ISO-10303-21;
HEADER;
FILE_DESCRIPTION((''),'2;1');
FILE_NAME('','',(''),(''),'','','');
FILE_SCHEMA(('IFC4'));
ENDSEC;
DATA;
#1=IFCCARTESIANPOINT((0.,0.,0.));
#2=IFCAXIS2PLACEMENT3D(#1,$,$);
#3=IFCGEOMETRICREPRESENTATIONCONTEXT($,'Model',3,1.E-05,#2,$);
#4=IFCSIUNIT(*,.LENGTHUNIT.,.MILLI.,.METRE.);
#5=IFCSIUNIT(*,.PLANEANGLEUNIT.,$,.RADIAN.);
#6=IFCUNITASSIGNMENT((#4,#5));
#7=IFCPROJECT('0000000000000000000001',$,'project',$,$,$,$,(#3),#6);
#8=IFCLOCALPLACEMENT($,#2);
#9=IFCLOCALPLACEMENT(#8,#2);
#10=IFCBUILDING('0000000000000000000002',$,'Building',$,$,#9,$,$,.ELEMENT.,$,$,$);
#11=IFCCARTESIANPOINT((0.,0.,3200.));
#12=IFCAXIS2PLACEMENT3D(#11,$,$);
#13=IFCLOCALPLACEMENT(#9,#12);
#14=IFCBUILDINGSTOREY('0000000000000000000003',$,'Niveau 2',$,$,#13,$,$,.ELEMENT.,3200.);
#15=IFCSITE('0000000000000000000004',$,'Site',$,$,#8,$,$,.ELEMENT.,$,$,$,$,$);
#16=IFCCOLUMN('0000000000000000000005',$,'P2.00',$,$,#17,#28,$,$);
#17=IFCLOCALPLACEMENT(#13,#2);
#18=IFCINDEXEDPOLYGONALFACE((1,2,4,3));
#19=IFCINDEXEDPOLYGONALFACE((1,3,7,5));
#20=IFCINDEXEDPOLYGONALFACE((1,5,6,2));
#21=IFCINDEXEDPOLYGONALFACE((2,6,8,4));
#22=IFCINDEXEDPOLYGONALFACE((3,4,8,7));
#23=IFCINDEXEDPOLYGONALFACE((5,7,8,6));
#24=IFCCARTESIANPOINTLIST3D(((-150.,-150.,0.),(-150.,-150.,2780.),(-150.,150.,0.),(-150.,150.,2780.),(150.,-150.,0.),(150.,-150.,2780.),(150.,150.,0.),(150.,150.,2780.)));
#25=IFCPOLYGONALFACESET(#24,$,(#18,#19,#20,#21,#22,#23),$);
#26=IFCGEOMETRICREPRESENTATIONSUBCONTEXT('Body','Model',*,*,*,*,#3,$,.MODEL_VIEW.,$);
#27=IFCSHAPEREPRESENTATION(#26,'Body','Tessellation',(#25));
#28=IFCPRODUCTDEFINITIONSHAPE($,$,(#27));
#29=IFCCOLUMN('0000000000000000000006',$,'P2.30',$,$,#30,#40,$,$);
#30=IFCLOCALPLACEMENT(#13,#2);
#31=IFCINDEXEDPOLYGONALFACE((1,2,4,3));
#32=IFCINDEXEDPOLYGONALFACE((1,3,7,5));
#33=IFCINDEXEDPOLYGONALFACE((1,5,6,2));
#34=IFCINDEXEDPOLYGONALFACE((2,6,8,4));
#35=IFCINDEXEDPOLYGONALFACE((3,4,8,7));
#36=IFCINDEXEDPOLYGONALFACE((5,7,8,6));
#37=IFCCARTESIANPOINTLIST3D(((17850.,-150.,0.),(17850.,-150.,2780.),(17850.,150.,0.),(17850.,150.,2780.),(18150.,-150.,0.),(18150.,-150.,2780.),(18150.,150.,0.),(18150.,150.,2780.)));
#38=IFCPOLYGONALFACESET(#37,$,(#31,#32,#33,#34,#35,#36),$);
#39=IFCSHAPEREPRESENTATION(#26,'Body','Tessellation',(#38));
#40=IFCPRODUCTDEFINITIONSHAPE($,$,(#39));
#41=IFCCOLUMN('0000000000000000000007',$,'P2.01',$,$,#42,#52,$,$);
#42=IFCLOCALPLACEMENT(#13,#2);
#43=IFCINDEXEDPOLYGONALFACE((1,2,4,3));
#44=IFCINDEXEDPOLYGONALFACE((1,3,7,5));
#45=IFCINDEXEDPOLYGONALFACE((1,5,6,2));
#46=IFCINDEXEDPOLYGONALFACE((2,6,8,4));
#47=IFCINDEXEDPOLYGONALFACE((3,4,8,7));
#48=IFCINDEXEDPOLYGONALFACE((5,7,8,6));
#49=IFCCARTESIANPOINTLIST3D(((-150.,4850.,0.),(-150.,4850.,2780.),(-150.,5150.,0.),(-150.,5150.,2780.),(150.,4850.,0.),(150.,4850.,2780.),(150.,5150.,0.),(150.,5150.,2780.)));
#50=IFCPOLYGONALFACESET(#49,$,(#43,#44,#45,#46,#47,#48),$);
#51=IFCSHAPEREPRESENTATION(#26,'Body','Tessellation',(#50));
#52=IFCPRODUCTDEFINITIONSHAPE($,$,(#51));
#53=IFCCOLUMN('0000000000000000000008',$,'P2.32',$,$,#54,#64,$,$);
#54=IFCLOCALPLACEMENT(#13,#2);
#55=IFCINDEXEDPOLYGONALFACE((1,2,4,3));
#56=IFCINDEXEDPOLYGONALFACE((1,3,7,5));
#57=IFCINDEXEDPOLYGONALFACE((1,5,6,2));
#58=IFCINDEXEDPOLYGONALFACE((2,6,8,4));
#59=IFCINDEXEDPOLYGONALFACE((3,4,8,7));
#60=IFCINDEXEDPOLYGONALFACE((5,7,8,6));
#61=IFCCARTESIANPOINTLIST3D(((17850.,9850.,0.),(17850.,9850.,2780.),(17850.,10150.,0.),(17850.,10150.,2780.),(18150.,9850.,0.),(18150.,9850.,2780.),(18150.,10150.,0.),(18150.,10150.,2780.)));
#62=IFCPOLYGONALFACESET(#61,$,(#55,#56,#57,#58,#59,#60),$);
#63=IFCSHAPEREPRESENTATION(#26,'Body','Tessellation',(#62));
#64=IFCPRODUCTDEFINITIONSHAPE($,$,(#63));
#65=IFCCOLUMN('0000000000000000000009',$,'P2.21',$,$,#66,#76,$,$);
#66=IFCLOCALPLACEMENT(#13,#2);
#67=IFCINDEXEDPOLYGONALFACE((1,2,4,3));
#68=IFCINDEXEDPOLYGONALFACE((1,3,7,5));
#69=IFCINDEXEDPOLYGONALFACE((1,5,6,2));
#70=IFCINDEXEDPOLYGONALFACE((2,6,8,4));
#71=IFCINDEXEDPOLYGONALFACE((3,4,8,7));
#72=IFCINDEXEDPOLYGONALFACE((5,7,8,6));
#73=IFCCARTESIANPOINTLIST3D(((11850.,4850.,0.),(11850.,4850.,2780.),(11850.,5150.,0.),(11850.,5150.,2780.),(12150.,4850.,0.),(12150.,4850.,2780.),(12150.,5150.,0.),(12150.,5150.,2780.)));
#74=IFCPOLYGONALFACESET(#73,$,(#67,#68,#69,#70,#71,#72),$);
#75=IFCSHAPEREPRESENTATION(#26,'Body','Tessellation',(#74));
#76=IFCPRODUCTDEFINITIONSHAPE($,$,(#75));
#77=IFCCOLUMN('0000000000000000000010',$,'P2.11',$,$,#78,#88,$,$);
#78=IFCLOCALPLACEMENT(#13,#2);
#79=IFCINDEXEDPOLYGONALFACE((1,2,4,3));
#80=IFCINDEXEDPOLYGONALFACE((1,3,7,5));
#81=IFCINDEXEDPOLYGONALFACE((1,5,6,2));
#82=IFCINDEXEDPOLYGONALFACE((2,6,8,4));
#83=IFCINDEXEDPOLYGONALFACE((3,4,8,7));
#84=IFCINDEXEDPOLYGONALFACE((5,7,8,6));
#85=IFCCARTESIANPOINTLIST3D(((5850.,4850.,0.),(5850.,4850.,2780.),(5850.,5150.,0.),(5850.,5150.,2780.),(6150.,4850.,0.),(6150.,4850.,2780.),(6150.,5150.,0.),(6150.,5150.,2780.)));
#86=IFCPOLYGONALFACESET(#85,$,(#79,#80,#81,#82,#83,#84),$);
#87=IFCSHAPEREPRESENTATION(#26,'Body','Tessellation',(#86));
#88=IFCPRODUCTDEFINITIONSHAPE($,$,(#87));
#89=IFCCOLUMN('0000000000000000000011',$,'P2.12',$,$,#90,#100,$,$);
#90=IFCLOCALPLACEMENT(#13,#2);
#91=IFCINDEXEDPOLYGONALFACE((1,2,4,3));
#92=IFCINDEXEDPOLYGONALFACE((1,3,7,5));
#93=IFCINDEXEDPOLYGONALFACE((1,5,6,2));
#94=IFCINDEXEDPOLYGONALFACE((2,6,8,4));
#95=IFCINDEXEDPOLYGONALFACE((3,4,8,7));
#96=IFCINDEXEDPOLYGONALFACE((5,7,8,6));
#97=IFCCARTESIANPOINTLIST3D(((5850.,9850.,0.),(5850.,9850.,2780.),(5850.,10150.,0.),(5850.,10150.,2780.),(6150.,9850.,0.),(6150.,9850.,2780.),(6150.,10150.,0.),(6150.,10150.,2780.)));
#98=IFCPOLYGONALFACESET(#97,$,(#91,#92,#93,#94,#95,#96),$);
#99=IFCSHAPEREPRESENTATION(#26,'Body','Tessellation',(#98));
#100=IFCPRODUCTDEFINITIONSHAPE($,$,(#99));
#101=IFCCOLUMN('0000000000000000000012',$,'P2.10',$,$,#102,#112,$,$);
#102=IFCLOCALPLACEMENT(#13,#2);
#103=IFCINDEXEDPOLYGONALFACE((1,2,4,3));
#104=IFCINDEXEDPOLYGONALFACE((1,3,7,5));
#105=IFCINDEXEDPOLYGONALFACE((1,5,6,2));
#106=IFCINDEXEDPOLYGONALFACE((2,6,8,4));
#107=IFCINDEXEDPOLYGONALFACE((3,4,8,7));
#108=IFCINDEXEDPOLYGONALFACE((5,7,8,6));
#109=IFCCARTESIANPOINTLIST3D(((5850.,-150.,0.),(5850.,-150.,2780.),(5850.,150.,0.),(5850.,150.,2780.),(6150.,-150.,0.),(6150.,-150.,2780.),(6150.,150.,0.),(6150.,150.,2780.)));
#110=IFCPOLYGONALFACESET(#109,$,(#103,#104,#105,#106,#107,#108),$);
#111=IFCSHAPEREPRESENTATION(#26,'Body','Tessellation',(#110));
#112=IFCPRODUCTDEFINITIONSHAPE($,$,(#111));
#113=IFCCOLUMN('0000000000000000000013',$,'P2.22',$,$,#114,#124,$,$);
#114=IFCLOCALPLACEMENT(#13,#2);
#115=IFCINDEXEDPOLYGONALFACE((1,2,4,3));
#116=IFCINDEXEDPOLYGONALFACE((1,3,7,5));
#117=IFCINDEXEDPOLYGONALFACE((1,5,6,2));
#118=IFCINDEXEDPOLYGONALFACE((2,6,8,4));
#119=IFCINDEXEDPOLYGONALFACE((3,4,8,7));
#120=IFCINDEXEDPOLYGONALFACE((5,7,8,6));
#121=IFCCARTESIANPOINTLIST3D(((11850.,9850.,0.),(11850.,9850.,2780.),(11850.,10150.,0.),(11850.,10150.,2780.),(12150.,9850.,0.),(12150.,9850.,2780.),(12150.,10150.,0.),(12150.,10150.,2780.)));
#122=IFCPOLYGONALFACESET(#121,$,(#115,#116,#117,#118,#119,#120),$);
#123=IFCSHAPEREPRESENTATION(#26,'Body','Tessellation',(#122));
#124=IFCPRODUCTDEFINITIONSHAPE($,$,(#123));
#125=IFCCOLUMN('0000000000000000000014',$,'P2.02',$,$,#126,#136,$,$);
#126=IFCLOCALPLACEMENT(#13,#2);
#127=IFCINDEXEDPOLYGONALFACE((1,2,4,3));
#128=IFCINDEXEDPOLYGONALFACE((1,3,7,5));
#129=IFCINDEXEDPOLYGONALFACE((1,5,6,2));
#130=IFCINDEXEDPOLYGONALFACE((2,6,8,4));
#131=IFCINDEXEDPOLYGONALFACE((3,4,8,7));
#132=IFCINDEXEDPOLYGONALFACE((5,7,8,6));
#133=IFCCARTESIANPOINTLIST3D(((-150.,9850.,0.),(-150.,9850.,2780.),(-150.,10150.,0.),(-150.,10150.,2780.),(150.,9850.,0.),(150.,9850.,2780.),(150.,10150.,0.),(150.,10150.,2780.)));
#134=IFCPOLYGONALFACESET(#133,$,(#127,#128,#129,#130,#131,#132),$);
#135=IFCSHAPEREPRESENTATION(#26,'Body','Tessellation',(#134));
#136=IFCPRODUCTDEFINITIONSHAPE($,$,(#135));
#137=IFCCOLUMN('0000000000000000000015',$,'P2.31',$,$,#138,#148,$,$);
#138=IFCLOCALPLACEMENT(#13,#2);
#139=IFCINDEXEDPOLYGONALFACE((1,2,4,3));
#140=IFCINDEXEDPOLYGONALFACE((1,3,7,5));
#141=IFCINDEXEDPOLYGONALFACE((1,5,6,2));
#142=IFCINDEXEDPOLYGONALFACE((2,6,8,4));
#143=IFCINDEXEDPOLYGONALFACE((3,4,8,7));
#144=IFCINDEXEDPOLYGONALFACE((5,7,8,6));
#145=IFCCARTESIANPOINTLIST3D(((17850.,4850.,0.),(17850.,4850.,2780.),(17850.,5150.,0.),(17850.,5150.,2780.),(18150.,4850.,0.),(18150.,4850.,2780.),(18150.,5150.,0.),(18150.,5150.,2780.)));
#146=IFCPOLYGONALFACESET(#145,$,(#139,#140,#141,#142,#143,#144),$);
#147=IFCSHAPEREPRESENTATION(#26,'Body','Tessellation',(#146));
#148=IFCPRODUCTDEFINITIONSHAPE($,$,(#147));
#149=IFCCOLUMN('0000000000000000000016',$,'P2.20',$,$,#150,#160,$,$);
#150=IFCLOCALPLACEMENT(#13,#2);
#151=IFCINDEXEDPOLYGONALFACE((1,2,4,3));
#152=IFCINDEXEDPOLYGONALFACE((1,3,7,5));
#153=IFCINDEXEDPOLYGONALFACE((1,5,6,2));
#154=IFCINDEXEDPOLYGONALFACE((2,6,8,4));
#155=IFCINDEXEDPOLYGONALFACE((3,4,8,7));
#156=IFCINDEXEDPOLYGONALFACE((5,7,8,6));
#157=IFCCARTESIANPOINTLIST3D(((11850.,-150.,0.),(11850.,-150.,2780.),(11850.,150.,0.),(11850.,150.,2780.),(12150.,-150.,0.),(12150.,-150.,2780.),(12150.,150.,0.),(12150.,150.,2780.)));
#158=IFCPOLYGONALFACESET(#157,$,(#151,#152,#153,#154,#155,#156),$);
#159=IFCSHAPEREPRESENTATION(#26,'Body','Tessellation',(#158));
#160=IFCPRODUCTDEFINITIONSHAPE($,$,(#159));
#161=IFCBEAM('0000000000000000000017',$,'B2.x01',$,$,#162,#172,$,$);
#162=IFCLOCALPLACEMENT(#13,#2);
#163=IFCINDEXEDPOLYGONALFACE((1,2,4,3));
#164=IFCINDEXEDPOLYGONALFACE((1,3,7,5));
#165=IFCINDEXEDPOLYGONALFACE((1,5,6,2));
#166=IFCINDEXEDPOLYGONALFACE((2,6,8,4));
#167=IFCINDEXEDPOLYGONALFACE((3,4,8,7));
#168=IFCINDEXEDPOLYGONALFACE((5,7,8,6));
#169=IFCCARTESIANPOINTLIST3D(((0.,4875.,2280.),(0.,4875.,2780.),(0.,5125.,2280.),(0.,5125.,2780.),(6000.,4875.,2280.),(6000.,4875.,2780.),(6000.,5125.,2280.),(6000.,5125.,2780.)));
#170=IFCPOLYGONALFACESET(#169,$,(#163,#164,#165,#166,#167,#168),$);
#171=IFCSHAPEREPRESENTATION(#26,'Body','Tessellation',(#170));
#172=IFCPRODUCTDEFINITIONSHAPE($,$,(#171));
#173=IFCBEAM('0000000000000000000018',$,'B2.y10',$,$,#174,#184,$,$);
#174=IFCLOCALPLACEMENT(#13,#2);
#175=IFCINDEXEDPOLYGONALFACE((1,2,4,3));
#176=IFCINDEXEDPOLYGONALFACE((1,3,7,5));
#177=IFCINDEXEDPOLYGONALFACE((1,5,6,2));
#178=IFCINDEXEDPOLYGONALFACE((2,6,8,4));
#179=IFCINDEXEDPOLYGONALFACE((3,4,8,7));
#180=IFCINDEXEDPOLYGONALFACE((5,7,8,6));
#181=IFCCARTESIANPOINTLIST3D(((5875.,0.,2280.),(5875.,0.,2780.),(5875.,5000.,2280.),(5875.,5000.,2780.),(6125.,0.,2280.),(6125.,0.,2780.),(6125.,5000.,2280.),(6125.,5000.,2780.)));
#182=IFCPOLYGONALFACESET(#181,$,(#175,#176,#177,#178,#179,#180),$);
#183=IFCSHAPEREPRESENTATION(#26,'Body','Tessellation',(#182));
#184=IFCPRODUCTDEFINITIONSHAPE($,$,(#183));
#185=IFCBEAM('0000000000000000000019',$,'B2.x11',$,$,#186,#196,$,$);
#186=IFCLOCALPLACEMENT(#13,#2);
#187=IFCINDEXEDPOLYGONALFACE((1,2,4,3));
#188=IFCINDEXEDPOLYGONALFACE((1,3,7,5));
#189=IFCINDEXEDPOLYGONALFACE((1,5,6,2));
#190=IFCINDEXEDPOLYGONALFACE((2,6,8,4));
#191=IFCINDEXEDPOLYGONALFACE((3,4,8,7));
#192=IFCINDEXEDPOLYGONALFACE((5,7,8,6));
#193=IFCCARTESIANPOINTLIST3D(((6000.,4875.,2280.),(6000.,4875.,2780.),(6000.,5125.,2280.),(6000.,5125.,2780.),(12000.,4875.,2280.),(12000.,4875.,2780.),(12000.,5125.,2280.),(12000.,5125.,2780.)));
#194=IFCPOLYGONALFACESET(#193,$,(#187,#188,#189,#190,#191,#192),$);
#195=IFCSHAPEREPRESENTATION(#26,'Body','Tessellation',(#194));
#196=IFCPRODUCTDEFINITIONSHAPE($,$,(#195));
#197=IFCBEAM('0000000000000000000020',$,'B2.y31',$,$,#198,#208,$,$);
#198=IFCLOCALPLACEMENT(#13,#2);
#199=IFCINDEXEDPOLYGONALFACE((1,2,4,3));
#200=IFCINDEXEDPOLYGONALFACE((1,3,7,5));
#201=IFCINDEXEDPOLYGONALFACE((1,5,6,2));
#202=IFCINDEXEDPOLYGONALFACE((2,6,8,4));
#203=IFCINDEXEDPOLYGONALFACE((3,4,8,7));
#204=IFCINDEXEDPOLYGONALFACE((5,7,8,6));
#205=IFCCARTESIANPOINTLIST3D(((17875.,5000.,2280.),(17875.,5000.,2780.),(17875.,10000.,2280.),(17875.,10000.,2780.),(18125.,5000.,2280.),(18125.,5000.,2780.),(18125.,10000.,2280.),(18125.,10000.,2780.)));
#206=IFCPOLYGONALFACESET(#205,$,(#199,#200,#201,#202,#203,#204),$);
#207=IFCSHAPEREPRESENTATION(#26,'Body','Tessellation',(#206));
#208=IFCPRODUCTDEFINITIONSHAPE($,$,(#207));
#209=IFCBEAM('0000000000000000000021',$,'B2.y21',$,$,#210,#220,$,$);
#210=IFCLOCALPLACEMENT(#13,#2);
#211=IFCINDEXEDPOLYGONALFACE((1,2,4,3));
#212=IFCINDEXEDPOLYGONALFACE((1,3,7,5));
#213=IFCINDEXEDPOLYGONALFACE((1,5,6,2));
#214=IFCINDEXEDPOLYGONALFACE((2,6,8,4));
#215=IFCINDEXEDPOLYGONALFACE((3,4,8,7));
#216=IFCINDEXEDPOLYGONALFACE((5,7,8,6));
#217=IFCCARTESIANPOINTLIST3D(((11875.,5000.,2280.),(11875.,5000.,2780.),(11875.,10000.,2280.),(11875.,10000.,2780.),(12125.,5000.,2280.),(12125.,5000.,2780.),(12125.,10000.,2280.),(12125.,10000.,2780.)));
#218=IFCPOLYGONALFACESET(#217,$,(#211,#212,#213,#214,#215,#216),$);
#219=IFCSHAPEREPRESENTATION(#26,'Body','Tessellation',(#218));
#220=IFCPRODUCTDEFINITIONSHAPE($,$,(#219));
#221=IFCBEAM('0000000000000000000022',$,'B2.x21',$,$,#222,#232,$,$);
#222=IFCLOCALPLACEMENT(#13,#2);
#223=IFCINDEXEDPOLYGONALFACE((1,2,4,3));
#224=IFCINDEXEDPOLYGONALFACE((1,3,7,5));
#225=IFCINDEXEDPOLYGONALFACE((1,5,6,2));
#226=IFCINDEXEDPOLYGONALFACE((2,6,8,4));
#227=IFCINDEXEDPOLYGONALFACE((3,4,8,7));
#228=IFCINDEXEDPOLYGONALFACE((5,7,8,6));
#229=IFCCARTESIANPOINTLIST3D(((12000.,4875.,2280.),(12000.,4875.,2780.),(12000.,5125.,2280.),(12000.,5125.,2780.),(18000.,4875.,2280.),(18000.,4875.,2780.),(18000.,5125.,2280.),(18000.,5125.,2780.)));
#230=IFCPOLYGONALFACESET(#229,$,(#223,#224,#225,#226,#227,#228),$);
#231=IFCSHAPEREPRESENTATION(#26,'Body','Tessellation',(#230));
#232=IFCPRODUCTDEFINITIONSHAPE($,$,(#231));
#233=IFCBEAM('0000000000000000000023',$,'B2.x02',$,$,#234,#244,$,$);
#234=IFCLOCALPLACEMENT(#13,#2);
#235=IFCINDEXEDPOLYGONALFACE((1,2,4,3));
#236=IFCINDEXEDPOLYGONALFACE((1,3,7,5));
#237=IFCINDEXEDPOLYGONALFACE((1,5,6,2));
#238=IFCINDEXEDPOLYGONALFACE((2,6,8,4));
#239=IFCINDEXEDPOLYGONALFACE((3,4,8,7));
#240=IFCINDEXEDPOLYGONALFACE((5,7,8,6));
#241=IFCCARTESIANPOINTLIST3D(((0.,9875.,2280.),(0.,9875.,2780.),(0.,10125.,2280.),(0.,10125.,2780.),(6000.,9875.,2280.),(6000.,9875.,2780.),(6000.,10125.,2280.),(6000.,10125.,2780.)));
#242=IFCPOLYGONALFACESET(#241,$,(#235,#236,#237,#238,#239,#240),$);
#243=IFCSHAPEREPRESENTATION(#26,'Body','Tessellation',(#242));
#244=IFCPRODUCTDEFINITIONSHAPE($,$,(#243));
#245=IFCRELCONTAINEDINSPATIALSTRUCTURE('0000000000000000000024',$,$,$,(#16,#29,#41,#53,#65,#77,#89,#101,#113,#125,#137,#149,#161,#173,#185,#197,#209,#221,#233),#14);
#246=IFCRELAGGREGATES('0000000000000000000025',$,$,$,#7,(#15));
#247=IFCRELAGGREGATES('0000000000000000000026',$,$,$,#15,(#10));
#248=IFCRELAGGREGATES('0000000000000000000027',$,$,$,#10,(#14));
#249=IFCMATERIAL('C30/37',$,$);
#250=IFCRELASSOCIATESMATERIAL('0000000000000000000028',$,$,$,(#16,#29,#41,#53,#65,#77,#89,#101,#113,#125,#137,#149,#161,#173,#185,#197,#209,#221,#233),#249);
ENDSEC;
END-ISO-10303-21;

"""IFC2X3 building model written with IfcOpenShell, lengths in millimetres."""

from ifc_helpers import new_model, si_unit, frame, origin, origin_2d, place, context, subcontext, project, spatial, rectangle, extrude, material, element, save


model = new_model("IFC2X3")

# Units and contexts
model_context = context("Model", 3, precision=1e-05, world=origin())
body_context = subcontext(model_context, "Body", "Model", "MODEL_VIEW")
ifc_project = project(units=[si_unit("LENGTHUNIT", "METRE", prefix="MILLI"), si_unit("PLANEANGLEUNIT", "RADIAN")], contexts=[model_context])

# Site, building, storey
site_placement = place(None, origin())
site = spatial("IfcSite", under=ifc_project, at=site_placement, Name="Site", CompositionType="ELEMENT")
building_placement = place(site_placement, origin())
building = spatial("IfcBuilding", under=site, at=building_placement, Name="Building", CompositionType="ELEMENT")
storey_placement = place(building_placement, frame((0.0, 0.0, 3200.0)))
storey = spatial("IfcBuildingStorey", under=building, at=storey_placement, Name="Niveau 2", CompositionType="ELEMENT", Elevation=3200.0)

# Columns
ifc_material = material(Name="C30/37")
for number, where, z_axis, x_axis, name in (
    (1, (0.0, 0.0, 0.0), (0.0, 0.0, 1.0), (1.0, 0.0, 0.0), "P2.00"),
    (2, (18000.0, 0.0, 0.0), (0.0, 0.0, 1.0), (1.0, 0.0, 0.0), "P2.30"),
    (3, (0.0, 5000.0, 0.0), (0.0, 0.0, 1.0), (1.0, 0.0, 0.0), "P2.01"),
    (4, (18000.0, 10000.0, 0.0), (0.0, 0.0, 1.0), (1.0, 0.0, 0.0), "P2.32"),
    (5, (12000.0, 5000.0, 0.0), (0.0, 0.0, 1.0), (1.0, 0.0, 0.0), "P2.21"),
    (6, (6000.0, 5000.0, 0.0), (0.0, 0.0, 1.0), (1.0, 0.0, 0.0), "P2.11"),
    (7, (6000.0, 10000.0, 0.0), (0.0, 0.0, 1.0), (1.0, 0.0, 0.0), "P2.12"),
    (8, (6000.0, 0.0, 0.0), (0.0, 0.0, 1.0), (1.0, 0.0, 0.0), "P2.10"),
    (9, (12000.0, 10000.0, 0.0), (0.0, 0.0, 1.0), (1.0, 0.0, 0.0), "P2.22"),
    (10, (0.0, 10000.0, 0.0), (0.0, 0.0, 1.0), (1.0, 0.0, 0.0), "P2.02"),
    (11, (18000.0, 5000.0, 0.0), (0.0, 0.0, 1.0), (1.0, 0.0, 0.0), "P2.31"),
    (12, (12000.0, 0.0, 0.0), (0.0, 0.0, 1.0), (1.0, 0.0, 0.0), "P2.20"),
):
    element("IfcColumn", number, at=place(storey_placement, frame(where, z_axis=z_axis, x_axis=x_axis)), inside=storey, material=ifc_material, Name=name, context=body_context, shape_type="SweptSolid", body=[
        extrude(rectangle(XDim=300.0, YDim=300.0, at=origin_2d()), origin(), (0.0, 0.0, 1.0), 2780.0),
    ])

# Beams
beam_1_placement = place(storey_placement, frame((0.0, 5000.0, 2530.0), z_axis=(1.0, 0.0, 0.0), x_axis=(0.0, 1.0, 0.0)))
element("IfcBeam", 13, at=beam_1_placement, inside=storey, material=ifc_material, Name="B2.x01", context=body_context, shape_type="SweptSolid", body=[
    extrude(rectangle(XDim=250.0, YDim=500.0, at=origin_2d()), origin(), (0.0, 0.0, 1.0), 6000.0),
])
beam_2_placement = place(storey_placement, frame((6000.0, 0.0, 2530.0), z_axis=(0.0, 1.0, 0.0), x_axis=(-1.0, 0.0, 0.0)))
element("IfcBeam", 14, at=beam_2_placement, inside=storey, material=ifc_material, Name="B2.y10", context=body_context, shape_type="SweptSolid", body=[
    extrude(rectangle(XDim=250.0, YDim=500.0, at=origin_2d()), origin(), (0.0, 0.0, 1.0), 5000.0),
])
beam_3_placement = place(storey_placement, frame((6000.0, 5000.0, 2530.0), z_axis=(1.0, 0.0, 0.0), x_axis=(0.0, 1.0, 0.0)))
element("IfcBeam", 15, at=beam_3_placement, inside=storey, material=ifc_material, Name="B2.x11", context=body_context, shape_type="SweptSolid", body=[
    extrude(rectangle(XDim=250.0, YDim=500.0, at=origin_2d()), origin(), (0.0, 0.0, 1.0), 6000.0),
])
for number, where, z_axis, x_axis, name in (
    (16, (18000.0, 5000.0, 2530.0), (0.0, 1.0, 0.0), (-1.0, 0.0, 0.0), "B2.y31"),
    (17, (12000.0, 5000.0, 2530.0), (0.0, 1.0, 0.0), (-1.0, 0.0, 0.0), "B2.y21"),
):
    element("IfcBeam", number, at=place(storey_placement, frame(where, z_axis=z_axis, x_axis=x_axis)), inside=storey, material=ifc_material, Name=name, context=body_context, shape_type="SweptSolid", body=[
        extrude(rectangle(XDim=250.0, YDim=500.0, at=origin_2d()), origin(), (0.0, 0.0, 1.0), 5000.0),
    ])
for number, where, z_axis, x_axis, name in (
    (18, (12000.0, 5000.0, 2530.0), (1.0, 0.0, 0.0), (0.0, 1.0, 0.0), "B2.x21"),
    (19, (0.0, 10000.0, 2530.0), (1.0, 0.0, 0.0), (0.0, 1.0, 0.0), "B2.x02"),
):
    element("IfcBeam", number, at=place(storey_placement, frame(where, z_axis=z_axis, x_axis=x_axis)), inside=storey, material=ifc_material, Name=name, context=body_context, shape_type="SweptSolid", body=[
        extrude(rectangle(XDim=250.0, YDim=500.0, at=origin_2d()), origin(), (0.0, 0.0, 1.0), 6000.0),
    ])

save(model, "model.ifc")
